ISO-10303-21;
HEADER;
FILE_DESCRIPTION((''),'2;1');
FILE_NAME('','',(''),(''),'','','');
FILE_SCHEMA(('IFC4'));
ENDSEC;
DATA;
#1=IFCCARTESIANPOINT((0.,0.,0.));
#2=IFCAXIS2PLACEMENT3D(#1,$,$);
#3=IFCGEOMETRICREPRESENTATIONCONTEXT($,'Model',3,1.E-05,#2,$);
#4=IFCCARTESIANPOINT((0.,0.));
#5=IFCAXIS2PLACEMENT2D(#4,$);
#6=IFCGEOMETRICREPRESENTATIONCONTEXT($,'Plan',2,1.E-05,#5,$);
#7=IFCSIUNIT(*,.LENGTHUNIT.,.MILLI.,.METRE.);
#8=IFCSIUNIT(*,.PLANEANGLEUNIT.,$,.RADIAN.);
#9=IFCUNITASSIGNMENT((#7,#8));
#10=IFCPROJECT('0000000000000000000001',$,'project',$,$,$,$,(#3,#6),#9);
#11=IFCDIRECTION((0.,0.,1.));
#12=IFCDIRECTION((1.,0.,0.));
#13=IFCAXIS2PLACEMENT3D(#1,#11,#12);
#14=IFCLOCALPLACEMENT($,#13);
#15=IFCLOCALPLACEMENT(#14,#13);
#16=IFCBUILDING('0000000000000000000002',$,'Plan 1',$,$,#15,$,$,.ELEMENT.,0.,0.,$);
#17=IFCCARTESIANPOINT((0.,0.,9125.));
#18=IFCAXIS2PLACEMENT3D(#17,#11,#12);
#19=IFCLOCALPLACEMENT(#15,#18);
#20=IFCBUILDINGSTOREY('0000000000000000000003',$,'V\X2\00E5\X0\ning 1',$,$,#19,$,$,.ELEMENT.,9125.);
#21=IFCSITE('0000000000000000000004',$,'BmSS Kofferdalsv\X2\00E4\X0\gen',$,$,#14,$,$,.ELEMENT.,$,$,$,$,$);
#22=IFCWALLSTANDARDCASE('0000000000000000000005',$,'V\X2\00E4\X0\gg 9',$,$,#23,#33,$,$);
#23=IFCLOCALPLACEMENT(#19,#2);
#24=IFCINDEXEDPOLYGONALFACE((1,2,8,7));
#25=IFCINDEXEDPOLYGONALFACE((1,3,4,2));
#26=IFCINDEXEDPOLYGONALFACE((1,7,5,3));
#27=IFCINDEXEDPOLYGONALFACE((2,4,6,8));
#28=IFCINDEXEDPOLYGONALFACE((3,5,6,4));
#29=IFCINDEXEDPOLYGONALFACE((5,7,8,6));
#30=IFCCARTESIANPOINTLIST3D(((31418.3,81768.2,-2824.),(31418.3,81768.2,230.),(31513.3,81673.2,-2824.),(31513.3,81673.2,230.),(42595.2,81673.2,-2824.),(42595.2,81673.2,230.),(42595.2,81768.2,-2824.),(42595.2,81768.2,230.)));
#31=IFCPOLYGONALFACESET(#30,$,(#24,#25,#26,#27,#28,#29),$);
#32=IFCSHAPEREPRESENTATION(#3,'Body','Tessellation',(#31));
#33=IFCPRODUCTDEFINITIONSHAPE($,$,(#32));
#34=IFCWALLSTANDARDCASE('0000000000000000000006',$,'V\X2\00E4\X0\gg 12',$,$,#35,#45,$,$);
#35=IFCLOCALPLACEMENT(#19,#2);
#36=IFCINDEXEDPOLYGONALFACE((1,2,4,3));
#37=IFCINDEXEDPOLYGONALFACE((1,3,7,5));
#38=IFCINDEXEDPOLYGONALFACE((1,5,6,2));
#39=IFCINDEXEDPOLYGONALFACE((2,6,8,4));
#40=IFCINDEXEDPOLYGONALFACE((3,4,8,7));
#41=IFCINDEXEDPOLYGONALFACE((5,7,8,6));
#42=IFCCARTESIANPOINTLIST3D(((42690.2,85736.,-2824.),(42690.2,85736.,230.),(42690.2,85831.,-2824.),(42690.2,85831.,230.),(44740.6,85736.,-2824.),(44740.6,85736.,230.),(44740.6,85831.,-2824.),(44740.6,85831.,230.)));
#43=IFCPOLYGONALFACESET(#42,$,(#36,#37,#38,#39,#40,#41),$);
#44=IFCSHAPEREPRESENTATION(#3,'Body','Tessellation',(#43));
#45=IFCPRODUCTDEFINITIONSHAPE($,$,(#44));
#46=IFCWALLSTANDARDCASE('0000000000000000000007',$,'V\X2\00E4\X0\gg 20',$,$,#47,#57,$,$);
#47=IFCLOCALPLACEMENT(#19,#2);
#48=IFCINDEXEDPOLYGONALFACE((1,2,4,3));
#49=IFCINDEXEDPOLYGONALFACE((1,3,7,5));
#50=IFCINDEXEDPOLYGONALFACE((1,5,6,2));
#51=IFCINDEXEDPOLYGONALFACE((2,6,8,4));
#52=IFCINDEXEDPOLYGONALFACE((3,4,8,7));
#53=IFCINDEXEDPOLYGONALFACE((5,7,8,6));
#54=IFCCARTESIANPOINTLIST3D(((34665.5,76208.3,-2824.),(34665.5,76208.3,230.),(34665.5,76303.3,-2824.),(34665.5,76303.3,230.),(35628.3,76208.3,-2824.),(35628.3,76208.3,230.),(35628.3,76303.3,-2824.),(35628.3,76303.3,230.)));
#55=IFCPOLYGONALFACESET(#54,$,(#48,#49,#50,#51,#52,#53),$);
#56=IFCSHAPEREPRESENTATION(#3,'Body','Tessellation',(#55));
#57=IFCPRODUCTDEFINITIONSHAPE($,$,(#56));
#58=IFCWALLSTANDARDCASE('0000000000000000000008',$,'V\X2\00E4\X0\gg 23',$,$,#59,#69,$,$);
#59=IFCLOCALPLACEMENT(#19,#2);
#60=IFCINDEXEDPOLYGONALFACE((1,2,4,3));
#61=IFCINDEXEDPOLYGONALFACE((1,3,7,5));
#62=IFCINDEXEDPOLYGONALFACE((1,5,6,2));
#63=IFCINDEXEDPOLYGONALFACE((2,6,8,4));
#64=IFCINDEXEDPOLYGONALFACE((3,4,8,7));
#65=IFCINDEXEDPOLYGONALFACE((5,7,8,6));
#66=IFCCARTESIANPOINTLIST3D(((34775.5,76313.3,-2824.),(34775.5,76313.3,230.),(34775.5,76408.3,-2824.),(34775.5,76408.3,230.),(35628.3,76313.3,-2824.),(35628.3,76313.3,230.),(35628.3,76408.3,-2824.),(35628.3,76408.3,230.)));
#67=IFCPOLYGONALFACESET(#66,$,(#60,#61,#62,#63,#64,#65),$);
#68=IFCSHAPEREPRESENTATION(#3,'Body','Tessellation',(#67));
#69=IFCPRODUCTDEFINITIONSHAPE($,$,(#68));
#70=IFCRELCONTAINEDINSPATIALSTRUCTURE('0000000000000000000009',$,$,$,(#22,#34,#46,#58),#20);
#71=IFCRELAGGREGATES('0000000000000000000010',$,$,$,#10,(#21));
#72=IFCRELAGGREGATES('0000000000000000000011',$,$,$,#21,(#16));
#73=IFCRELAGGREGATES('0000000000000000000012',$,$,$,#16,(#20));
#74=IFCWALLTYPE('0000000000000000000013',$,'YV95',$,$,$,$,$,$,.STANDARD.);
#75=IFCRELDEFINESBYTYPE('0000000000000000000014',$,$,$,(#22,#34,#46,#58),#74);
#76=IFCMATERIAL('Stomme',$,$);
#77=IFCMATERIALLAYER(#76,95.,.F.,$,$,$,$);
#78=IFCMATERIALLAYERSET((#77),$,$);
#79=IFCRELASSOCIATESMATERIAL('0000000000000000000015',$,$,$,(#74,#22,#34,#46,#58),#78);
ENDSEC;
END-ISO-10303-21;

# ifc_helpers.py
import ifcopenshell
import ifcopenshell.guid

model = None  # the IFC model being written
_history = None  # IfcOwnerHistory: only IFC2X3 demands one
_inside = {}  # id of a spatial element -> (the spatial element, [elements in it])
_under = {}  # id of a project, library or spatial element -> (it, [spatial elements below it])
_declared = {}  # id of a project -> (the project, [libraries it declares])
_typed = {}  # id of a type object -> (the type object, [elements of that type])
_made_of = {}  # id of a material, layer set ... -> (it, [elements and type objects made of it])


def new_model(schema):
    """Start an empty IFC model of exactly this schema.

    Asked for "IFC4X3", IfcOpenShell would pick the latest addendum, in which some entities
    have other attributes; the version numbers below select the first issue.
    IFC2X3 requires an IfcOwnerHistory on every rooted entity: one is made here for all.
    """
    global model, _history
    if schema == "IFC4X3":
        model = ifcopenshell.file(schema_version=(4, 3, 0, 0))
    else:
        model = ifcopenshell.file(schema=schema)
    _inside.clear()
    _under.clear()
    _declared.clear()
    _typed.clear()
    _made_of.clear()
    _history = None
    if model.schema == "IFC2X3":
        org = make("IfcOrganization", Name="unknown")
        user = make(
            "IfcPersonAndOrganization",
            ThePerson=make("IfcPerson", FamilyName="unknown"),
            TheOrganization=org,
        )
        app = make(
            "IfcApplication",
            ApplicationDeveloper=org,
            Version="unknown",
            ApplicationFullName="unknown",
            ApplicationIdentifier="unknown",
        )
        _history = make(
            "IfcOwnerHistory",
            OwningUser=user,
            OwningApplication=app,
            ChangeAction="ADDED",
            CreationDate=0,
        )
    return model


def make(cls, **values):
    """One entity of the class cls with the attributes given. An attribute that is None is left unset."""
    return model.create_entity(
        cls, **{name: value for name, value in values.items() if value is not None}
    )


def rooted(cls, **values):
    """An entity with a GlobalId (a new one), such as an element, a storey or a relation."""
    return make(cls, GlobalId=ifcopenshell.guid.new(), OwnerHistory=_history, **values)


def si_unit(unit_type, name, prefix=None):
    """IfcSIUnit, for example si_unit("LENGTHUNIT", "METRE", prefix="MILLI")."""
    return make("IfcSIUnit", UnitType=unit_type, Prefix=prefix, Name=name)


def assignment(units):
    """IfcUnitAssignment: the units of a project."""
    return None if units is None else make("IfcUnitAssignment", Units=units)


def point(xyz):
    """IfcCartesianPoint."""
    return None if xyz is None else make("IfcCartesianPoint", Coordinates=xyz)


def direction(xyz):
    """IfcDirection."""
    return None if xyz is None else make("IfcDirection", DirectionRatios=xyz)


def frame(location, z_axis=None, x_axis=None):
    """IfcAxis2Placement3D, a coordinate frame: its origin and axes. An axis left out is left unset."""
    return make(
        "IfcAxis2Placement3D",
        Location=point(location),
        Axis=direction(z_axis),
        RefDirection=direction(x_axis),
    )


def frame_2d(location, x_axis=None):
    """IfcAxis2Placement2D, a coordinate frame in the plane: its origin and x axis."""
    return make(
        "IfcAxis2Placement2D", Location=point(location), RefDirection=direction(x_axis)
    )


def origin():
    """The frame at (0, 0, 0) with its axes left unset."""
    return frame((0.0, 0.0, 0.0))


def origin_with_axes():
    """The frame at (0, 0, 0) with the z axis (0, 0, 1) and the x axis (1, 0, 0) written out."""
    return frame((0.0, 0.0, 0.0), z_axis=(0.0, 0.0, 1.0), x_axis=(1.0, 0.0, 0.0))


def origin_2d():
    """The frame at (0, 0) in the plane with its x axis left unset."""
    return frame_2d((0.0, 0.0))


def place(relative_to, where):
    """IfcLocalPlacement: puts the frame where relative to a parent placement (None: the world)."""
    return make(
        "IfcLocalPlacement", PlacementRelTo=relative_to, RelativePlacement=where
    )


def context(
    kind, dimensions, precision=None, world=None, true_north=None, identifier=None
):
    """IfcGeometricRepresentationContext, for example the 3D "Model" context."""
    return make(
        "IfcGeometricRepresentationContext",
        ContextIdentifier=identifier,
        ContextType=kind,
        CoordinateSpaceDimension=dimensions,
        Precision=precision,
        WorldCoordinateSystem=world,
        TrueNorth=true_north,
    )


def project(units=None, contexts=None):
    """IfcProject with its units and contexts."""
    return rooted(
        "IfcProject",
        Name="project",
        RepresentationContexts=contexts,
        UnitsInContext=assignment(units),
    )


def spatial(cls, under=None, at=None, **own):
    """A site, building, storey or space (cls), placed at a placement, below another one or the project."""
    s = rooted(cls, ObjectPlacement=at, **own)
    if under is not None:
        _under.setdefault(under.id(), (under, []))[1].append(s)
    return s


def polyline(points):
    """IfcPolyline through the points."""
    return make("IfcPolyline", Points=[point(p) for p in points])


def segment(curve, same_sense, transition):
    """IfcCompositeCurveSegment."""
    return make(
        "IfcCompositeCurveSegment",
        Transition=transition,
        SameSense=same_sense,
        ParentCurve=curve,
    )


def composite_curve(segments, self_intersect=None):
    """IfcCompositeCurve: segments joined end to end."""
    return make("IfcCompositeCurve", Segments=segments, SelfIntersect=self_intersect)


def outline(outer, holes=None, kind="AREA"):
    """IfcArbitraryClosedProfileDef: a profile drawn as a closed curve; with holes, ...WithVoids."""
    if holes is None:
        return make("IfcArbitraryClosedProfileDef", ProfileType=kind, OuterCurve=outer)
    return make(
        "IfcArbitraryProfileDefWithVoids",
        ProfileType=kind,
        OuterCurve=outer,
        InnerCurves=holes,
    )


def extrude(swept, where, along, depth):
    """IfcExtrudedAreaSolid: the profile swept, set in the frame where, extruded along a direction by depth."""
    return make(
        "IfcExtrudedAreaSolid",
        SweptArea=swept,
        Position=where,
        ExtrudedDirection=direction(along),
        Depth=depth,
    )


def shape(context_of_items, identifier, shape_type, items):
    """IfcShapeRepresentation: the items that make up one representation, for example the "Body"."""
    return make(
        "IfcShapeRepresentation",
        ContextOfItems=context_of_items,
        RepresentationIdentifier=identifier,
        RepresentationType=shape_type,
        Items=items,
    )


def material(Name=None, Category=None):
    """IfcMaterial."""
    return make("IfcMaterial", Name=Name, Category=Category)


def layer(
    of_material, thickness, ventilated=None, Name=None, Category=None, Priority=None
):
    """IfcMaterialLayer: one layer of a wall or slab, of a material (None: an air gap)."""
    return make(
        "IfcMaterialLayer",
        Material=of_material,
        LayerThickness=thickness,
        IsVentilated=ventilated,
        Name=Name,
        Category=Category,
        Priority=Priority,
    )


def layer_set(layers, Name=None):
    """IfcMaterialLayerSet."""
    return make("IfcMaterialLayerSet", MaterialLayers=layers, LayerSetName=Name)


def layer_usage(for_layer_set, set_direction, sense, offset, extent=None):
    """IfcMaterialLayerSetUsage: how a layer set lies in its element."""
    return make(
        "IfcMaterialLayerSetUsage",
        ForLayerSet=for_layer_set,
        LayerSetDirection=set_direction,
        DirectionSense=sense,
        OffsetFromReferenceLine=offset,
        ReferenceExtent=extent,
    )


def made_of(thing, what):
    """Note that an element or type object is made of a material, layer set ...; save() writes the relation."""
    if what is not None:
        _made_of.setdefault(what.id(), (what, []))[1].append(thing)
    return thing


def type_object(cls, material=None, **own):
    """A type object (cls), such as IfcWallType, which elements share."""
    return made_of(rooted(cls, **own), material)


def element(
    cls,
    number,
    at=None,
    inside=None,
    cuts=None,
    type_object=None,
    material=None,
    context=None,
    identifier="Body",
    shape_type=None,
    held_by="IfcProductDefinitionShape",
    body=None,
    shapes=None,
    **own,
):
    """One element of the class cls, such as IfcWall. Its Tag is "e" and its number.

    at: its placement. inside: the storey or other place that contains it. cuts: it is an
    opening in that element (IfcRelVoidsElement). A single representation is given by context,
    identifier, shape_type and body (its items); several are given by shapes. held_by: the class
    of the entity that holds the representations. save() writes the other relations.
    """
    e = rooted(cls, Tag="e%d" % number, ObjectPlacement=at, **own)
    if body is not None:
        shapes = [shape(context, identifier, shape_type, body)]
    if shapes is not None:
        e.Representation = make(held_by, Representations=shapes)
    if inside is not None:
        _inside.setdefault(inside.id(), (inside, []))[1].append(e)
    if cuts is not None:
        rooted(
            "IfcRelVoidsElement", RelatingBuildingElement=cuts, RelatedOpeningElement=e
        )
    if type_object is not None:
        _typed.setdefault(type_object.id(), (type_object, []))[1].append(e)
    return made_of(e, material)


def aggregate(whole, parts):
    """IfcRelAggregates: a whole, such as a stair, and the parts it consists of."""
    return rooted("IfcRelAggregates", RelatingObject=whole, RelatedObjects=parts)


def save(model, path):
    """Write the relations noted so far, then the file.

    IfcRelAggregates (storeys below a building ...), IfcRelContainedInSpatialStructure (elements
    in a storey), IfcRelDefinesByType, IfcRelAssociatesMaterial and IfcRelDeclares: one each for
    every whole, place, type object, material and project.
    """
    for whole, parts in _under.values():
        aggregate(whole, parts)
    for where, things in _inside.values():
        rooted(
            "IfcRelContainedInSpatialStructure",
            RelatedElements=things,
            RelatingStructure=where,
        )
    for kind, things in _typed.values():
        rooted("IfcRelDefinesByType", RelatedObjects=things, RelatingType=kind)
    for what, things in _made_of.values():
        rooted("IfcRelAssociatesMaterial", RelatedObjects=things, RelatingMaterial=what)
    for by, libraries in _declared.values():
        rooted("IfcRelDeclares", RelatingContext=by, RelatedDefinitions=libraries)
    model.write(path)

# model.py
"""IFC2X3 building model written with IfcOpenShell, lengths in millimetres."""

from ifc_helpers import new_model, si_unit, frame, origin, origin_with_axes, origin_2d, place, context, project, spatial, polyline, segment, composite_curve, outline, extrude, material, layer, layer_set, layer_usage, type_object, element, save


model = new_model("IFC2X3")

# Units and contexts
model_context = context("Model", 3, precision=1e-05, world=origin())
plan_context = context("Plan", 2, precision=1e-05, world=origin_2d())
ifc_project = project(units=[si_unit("LENGTHUNIT", "METRE", prefix="MILLI"), si_unit("PLANEANGLEUNIT", "RADIAN")], contexts=[model_context, plan_context])

# Site, building, storey
site_placement = place(None, origin_with_axes())
site = spatial("IfcSite", under=ifc_project, at=site_placement, Name="BmSS Kofferdalsvägen", CompositionType="ELEMENT")
building_placement = place(site_placement, origin_with_axes())
building = spatial("IfcBuilding", under=site, at=building_placement, Name="Plan 1", CompositionType="ELEMENT", ElevationOfRefHeight=0.0, ElevationOfTerrain=0.0)
storey_placement = place(building_placement, frame((0.0, 0.0, 9125.0), z_axis=(0.0, 0.0, 1.0), x_axis=(1.0, 0.0, 0.0)))
storey = spatial("IfcBuildingStorey", under=building, at=storey_placement, Name="Våning 1", CompositionType="ELEMENT", Elevation=9125.0)

# Walls
ifc_material = material(Name="Stomme")
ifc_layer_1 = layer(ifc_material, 95.0, ventilated=False)
ifc_layer_set_1 = layer_set([ifc_layer_1])
wall_type_1 = type_object("IfcWallType", Name="YV95", PredefinedType="STANDARD", material=ifc_layer_set_1)
ifc_layer_usage_1 = layer_usage(ifc_layer_set_1, "AXIS2", "POSITIVE", -95.0)
wall_1_placement = place(storey_placement, frame((31418.3, 81768.2, -2824.0), z_axis=(0.0, 0.0, 1.0), x_axis=(1.0, 0.0, 0.0)))
element("IfcWallStandardCase", 1, at=wall_1_placement, inside=storey, type_object=wall_type_1, material=ifc_layer_usage_1, Name="Vägg 9", context=model_context, shape_type="SweptSolid", body=[
    extrude(outline(composite_curve([segment(polyline([(0.0, 0.0), (95.0, -95.0)]), True, "CONTINUOUS"), segment(polyline([(95.0, -95.0), (11176.9, -95.0)]), True, "CONTINUOUS"), segment(polyline([(11176.9, -95.0), (11176.9, 0.0)]), True, "CONTINUOUS"), segment(polyline([(11176.9, 0.0), (0.0, 0.0)]), True, "CONTINUOUS")], self_intersect=False)), origin_with_axes(), (0.0, 0.0, 1.0), 3054.0),
])
ifc_layer_usage_2 = layer_usage(ifc_layer_set_1, "AXIS2", "POSITIVE", 0.0)
wall_2_placement = place(storey_placement, frame((44740.6, 85831.0, -2824.0), z_axis=(0.0, 0.0, 1.0), x_axis=(-1.0, 0.0, 0.0)))
element("IfcWallStandardCase", 2, at=wall_2_placement, inside=storey, type_object=wall_type_1, material=ifc_layer_usage_2, Name="Vägg 12", context=model_context, shape_type="SweptSolid", body=[
    extrude(outline(composite_curve([segment(polyline([(0.0, 95.0), (0.0, 0.0)]), True, "CONTINUOUS"), segment(polyline([(0.0, 0.0), (2050.3, 0.0)]), True, "CONTINUOUS"), segment(polyline([(2050.3, 0.0), (2050.3, 95.0)]), True, "CONTINUOUS"), segment(polyline([(2050.3, 95.0), (0.0, 95.0)]), True, "CONTINUOUS")], self_intersect=False)), origin_with_axes(), (0.0, 0.0, 1.0), 3054.0),
])
ifc_layer_usage_3 = layer_usage(ifc_layer_set_1, "AXIS2", "POSITIVE", 0.0)
wall_3_placement = place(storey_placement, frame((34665.5, 76208.3, -2824.0), z_axis=(0.0, 0.0, 1.0), x_axis=(1.0, 0.0, 0.0)))
element("IfcWallStandardCase", 3, at=wall_3_placement, inside=storey, type_object=wall_type_1, material=ifc_layer_usage_3, Name="Vägg 20", context=model_context, shape_type="SweptSolid", body=[
    extrude(outline(composite_curve([segment(polyline([(0.0, 95.0), (0.0, 0.0)]), True, "CONTINUOUS"), segment(polyline([(0.0, 0.0), (962.8, 0.0)]), True, "CONTINUOUS"), segment(polyline([(962.8, 0.0), (962.8, 95.0)]), True, "CONTINUOUS"), segment(polyline([(962.8, 95.0), (0.0, 95.0)]), True, "CONTINUOUS")], self_intersect=False)), origin_with_axes(), (0.0, 0.0, 1.0), 3054.0),
])
ifc_layer_usage_4 = layer_usage(ifc_layer_set_1, "AXIS2", "POSITIVE", 0.0)
wall_4_placement = place(storey_placement, frame((34775.5, 76313.3, -2824.0), z_axis=(0.0, 0.0, 1.0), x_axis=(1.0, 0.0, 0.0)))
element("IfcWallStandardCase", 4, at=wall_4_placement, inside=storey, type_object=wall_type_1, material=ifc_layer_usage_4, Name="Vägg 23", context=model_context, shape_type="SweptSolid", body=[
    extrude(outline(composite_curve([segment(polyline([(0.0, 95.0), (0.0, 0.0)]), True, "CONTINUOUS"), segment(polyline([(0.0, 0.0), (852.8, 0.0)]), True, "CONTINUOUS"), segment(polyline([(852.8, 0.0), (852.8, 95.0)]), True, "CONTINUOUS"), segment(polyline([(852.8, 95.0), (0.0, 95.0)]), True, "CONTINUOUS")], self_intersect=False)), origin_with_axes(), (0.0, 0.0, 1.0), 3054.0),
])

save(model, "model.ifc")
